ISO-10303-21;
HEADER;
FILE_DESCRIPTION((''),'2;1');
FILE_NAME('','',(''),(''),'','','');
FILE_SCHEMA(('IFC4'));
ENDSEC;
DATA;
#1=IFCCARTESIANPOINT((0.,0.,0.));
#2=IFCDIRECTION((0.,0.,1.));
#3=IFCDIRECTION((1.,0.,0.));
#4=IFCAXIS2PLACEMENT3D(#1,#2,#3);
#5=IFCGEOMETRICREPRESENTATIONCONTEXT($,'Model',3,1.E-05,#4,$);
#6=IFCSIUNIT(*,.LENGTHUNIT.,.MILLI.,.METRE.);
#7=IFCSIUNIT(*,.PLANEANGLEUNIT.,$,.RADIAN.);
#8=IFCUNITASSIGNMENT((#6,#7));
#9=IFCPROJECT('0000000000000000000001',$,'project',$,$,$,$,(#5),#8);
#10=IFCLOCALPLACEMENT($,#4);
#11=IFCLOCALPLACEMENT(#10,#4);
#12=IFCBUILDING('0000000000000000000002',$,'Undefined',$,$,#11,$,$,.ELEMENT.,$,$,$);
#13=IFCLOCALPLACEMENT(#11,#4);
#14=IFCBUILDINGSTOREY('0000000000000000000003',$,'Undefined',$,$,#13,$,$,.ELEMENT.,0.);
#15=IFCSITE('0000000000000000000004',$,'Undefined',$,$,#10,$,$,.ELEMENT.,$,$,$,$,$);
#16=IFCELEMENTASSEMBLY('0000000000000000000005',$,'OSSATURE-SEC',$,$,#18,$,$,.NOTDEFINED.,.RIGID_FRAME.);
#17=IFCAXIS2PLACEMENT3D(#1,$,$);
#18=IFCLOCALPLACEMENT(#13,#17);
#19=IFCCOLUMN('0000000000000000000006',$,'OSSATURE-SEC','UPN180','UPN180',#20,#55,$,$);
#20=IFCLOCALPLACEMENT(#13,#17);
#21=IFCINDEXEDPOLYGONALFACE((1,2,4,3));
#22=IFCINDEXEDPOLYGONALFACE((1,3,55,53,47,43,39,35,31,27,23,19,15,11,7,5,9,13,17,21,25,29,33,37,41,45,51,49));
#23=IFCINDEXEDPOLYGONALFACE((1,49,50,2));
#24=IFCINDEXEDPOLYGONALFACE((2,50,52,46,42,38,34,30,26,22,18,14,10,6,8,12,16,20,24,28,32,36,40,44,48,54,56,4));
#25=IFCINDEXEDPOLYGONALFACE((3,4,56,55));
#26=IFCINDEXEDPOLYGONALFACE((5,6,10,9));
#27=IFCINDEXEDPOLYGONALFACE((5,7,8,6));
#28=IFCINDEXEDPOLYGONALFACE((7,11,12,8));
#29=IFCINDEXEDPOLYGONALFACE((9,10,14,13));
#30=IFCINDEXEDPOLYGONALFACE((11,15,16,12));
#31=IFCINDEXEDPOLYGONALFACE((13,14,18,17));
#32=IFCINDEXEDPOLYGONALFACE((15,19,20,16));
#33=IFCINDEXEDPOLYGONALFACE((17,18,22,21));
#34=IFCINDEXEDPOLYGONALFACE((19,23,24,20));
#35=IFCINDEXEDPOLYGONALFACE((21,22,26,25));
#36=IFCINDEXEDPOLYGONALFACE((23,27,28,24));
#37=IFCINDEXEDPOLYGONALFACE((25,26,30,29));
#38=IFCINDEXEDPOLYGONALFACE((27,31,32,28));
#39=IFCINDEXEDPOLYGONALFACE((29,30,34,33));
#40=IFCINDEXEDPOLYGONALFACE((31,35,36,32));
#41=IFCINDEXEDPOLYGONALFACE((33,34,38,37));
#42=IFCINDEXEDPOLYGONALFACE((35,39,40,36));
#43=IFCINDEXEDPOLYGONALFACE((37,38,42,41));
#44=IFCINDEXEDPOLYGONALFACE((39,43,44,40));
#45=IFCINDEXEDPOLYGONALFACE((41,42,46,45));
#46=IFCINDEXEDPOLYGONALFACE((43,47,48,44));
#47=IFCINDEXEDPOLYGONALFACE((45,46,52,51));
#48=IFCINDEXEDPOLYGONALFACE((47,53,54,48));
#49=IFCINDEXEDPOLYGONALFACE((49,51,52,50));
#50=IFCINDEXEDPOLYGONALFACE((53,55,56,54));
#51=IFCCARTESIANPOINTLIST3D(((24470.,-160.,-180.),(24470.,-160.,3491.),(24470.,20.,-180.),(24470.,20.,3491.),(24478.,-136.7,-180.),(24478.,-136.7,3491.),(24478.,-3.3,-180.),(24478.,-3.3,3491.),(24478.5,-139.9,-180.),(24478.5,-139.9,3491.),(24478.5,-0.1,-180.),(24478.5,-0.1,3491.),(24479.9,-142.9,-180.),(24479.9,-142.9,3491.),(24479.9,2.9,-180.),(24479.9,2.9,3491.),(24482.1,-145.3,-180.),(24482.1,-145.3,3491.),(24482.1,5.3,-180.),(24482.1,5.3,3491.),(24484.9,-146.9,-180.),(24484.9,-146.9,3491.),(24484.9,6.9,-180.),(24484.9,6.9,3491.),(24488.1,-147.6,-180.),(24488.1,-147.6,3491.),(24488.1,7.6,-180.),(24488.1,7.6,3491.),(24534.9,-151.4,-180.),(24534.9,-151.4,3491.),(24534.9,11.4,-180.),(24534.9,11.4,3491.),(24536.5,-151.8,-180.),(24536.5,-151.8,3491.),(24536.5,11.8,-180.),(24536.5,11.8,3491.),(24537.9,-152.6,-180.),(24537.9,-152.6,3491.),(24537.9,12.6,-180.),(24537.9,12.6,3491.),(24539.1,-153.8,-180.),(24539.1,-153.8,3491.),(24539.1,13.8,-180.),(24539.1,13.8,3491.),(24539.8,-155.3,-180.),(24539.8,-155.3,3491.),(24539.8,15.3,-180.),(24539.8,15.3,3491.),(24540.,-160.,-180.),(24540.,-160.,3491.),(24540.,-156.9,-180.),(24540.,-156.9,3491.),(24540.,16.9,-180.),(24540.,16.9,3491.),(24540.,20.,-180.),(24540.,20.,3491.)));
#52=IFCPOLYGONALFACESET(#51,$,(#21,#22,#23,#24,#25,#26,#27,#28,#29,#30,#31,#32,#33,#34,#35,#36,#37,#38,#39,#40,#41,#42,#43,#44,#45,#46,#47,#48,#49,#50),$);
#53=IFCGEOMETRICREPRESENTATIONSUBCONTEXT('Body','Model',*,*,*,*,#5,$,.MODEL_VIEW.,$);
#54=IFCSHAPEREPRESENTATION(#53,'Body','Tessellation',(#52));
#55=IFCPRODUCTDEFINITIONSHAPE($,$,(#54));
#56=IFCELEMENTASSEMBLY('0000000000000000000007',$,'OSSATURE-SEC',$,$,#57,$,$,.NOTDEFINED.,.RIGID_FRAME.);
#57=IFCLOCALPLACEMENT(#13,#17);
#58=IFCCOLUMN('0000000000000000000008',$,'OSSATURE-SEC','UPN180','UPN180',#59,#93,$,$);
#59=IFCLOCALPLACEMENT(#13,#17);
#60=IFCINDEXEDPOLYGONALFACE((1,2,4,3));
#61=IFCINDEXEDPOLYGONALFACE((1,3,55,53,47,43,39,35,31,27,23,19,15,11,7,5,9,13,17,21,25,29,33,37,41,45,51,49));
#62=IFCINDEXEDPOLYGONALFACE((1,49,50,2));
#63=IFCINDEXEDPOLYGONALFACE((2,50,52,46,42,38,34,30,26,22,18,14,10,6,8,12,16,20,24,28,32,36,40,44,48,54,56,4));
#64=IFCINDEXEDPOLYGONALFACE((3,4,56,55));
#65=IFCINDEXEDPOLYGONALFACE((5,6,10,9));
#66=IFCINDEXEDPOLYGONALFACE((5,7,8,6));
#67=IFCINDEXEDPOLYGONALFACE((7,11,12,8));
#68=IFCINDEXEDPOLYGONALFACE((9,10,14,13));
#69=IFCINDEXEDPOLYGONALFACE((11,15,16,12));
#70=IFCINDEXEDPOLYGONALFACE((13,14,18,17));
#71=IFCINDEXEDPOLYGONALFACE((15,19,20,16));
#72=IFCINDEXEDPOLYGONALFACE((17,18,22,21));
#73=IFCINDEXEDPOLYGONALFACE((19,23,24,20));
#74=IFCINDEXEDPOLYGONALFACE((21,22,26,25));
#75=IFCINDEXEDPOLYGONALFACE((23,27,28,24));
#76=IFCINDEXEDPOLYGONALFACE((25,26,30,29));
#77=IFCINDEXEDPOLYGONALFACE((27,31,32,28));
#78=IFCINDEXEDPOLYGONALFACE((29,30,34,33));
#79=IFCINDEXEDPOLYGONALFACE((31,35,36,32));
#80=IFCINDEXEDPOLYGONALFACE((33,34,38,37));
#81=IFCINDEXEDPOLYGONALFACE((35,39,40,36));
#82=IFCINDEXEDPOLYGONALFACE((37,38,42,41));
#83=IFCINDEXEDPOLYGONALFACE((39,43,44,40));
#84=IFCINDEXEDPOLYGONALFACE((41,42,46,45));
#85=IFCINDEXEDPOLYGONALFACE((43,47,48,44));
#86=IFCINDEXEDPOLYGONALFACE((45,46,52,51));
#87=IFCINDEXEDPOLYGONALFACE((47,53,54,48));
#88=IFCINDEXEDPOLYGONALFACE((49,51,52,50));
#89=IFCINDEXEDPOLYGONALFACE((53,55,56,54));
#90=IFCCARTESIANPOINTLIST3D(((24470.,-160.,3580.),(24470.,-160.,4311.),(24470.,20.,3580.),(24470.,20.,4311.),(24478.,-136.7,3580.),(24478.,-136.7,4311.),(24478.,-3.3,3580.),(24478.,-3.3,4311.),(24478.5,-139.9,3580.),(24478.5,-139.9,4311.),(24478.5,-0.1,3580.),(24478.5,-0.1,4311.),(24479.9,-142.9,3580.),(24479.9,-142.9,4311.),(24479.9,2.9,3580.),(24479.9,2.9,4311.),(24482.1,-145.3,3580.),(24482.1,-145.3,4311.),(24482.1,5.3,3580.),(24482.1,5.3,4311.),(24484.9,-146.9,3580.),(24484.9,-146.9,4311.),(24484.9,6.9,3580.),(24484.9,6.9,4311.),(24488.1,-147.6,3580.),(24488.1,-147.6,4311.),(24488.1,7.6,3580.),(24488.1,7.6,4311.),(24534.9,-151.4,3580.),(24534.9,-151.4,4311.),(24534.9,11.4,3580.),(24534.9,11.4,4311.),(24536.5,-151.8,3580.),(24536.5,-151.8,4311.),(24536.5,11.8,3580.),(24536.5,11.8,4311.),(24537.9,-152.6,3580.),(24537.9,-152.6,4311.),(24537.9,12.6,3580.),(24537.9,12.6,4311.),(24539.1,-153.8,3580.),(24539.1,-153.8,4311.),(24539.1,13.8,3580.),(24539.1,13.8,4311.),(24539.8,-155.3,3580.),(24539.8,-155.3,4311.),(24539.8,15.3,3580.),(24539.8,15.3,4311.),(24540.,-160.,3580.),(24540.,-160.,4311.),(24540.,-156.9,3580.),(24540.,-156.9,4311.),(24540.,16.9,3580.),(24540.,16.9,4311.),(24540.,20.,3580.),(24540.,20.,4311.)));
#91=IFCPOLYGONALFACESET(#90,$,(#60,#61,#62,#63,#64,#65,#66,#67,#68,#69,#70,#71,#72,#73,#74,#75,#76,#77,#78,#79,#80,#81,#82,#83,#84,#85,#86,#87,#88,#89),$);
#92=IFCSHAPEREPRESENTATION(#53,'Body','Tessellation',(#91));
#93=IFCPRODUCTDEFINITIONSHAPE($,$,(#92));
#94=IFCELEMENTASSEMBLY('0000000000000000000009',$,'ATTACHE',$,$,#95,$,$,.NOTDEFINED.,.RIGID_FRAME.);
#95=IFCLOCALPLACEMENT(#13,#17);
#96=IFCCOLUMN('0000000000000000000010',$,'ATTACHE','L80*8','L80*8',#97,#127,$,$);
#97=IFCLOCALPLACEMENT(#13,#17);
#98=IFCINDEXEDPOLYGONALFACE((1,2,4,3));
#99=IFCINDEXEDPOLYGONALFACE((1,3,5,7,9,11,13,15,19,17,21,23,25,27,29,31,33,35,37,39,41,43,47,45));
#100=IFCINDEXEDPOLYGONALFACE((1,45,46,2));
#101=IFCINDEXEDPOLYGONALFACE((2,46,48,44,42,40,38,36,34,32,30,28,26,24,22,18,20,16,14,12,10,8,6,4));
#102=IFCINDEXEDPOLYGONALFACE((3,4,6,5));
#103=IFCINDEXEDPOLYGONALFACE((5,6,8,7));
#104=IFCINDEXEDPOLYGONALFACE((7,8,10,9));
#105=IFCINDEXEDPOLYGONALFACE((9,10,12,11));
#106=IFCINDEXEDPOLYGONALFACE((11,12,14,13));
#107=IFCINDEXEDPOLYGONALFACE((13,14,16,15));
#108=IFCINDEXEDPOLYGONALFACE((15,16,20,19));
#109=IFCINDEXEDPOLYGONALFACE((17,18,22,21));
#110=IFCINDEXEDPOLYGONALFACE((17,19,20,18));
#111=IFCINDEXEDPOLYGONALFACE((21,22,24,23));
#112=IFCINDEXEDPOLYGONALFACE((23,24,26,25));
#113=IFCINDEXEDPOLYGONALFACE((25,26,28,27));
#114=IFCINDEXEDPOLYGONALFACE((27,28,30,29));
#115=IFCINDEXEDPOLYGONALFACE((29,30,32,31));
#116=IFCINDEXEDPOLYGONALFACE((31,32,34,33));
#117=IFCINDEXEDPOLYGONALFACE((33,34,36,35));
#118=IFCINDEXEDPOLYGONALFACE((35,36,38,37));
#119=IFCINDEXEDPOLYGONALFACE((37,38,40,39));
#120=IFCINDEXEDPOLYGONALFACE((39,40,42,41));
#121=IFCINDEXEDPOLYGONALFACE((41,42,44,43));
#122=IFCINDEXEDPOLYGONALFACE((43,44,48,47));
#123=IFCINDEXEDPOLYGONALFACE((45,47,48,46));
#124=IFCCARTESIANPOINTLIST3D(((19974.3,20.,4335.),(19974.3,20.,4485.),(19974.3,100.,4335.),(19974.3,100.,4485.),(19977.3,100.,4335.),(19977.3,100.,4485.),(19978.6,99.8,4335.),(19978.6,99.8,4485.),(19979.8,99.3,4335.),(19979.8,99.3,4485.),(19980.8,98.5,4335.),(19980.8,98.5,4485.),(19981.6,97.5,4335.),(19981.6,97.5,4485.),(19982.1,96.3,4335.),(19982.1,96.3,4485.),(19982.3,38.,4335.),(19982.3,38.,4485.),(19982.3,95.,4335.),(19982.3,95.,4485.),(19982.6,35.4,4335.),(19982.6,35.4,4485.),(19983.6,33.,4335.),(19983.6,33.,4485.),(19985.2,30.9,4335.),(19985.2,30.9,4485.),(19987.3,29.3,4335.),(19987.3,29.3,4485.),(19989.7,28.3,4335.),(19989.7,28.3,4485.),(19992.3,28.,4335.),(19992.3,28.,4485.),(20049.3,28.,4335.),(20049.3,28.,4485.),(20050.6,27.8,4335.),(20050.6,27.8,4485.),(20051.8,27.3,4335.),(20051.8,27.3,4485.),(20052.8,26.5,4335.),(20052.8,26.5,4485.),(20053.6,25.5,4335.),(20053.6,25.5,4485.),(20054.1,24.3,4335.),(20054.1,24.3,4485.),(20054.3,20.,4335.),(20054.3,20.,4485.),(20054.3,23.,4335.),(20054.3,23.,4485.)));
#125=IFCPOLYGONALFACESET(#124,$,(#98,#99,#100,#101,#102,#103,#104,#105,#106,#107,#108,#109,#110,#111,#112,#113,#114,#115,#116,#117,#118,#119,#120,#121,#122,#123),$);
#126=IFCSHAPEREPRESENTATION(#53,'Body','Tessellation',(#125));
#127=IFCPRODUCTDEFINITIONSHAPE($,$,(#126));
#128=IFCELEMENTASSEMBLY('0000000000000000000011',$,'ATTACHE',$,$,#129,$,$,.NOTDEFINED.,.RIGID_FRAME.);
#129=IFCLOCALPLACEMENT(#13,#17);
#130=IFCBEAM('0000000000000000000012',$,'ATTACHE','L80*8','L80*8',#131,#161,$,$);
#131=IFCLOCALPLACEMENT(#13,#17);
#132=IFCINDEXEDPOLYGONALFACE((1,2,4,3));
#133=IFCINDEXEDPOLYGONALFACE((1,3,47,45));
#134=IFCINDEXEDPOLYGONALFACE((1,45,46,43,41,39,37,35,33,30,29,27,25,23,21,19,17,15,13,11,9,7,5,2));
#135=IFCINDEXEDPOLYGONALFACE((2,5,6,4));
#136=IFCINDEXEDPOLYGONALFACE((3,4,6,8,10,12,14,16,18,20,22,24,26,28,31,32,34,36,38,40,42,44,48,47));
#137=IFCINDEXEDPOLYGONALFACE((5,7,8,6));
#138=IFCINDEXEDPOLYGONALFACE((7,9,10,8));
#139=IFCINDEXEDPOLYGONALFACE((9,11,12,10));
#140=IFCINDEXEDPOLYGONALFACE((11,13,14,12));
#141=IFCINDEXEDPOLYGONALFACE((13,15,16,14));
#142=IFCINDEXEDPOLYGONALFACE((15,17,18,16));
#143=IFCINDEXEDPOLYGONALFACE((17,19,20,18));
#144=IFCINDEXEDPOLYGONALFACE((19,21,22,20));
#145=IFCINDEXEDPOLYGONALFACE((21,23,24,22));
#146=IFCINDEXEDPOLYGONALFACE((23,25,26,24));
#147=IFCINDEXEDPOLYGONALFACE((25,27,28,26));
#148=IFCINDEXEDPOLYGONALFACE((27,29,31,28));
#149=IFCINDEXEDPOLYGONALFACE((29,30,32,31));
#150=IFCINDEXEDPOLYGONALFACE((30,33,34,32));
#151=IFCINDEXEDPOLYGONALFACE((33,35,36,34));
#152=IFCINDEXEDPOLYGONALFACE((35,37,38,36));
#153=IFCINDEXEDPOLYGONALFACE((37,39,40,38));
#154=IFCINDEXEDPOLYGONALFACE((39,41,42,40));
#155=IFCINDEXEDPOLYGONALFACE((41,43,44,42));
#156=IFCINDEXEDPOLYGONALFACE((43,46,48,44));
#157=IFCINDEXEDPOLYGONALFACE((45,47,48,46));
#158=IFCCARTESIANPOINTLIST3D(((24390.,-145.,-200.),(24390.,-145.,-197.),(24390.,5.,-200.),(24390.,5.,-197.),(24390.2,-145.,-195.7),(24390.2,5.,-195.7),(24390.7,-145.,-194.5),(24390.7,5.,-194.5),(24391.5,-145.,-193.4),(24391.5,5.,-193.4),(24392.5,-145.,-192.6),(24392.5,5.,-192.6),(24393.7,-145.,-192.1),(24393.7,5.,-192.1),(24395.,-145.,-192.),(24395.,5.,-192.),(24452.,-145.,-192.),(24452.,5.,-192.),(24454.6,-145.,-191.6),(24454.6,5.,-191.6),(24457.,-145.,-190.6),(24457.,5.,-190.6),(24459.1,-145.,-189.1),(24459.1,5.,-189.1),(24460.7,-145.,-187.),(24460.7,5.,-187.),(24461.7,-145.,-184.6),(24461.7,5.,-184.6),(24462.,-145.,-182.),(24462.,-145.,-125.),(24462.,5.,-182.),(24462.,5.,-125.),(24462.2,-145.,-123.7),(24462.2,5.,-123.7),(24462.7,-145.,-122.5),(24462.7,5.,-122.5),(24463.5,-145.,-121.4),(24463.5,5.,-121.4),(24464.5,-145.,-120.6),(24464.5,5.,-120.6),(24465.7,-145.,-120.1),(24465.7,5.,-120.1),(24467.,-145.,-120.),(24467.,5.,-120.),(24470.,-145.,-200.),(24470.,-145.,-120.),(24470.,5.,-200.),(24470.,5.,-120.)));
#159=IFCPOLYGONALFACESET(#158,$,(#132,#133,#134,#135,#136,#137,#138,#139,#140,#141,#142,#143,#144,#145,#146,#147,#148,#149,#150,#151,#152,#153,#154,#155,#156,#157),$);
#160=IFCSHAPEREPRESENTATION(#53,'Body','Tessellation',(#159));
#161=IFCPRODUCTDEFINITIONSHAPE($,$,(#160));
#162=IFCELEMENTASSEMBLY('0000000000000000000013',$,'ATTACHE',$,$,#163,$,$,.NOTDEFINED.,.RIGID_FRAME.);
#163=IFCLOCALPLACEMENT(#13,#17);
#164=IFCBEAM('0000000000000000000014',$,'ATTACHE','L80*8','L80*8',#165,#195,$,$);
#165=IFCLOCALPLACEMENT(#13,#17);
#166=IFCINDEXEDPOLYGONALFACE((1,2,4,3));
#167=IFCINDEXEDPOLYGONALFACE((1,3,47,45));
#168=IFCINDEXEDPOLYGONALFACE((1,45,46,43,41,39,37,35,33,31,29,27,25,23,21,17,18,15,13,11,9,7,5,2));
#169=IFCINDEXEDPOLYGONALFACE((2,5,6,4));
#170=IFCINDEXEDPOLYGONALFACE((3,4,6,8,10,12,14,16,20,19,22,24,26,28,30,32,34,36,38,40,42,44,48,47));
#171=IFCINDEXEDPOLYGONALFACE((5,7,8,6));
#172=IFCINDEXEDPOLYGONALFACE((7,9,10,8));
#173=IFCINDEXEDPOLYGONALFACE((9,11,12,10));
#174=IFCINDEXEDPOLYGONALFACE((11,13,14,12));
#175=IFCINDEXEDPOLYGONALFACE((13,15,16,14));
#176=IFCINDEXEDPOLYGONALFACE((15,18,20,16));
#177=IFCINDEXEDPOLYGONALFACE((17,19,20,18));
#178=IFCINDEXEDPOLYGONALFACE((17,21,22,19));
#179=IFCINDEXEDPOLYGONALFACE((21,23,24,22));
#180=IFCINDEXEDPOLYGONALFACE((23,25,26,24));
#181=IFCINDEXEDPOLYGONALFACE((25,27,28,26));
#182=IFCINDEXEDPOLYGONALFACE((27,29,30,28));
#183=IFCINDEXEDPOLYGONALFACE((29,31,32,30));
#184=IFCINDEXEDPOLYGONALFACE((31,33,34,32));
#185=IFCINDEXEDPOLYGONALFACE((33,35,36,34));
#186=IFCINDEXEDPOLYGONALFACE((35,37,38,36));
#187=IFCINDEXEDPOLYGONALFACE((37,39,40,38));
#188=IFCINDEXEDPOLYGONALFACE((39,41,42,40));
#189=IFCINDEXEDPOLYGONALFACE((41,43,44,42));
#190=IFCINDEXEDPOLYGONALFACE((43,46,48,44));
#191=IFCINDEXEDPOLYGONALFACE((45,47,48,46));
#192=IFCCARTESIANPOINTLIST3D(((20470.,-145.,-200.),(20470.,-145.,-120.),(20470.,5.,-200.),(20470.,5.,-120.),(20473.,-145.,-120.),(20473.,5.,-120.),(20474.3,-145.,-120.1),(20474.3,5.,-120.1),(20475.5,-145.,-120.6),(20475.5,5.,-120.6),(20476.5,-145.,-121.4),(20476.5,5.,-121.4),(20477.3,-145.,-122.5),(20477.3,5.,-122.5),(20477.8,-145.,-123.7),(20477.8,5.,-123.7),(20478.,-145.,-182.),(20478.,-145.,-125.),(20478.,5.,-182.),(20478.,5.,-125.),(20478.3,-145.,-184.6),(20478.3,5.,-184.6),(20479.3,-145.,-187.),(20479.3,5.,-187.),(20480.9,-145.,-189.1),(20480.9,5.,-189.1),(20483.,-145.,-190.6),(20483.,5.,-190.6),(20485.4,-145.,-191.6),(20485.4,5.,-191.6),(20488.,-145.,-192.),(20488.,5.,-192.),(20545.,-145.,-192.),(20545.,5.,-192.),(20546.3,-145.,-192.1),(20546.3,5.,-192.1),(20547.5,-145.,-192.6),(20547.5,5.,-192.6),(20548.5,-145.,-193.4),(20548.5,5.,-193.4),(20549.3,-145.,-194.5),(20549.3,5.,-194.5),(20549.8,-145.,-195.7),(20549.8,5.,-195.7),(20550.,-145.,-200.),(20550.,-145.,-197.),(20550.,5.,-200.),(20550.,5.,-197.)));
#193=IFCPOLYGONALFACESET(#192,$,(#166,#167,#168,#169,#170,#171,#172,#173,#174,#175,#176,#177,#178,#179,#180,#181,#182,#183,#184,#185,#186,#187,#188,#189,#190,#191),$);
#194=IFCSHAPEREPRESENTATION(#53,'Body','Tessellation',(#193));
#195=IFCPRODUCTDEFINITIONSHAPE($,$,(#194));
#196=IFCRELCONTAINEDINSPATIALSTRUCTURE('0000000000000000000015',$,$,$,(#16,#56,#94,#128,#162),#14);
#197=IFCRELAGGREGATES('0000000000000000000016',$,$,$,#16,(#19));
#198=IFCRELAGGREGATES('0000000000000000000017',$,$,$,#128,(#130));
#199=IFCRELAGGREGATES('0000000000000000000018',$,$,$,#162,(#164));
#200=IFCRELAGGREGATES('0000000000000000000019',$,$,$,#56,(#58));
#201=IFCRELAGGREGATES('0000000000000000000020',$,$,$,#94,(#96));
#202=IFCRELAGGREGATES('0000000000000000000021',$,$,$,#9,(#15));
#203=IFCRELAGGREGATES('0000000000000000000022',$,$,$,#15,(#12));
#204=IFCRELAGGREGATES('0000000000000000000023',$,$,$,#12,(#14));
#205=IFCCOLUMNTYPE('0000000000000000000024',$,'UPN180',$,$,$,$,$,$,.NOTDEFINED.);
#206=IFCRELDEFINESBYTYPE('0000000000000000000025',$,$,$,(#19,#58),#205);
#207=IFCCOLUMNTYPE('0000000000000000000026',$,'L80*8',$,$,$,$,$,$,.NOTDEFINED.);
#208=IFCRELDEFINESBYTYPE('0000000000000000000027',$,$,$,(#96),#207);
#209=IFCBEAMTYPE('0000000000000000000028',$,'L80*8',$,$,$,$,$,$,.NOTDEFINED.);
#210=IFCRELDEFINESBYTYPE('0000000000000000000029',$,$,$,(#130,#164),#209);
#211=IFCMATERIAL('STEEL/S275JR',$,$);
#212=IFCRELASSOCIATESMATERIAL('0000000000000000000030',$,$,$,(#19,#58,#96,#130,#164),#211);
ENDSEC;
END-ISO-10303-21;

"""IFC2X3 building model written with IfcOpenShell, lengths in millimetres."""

from ifc_helpers import new_model, si_unit, frame, origin_with_axes, origin_2d_with_axis, place, context, subcontext, project, spatial, l_section, u_section, extrude, clip, halfspace, material, type_object, element, aggregate, save


model = new_model("IFC2X3")

# Units and contexts
model_context = context("Model", 3, precision=1e-05, world=origin_with_axes())
body_context = subcontext(model_context, "Body", "Model", "MODEL_VIEW")
ifc_project = project(units=[si_unit("LENGTHUNIT", "METRE", prefix="MILLI"), si_unit("PLANEANGLEUNIT", "RADIAN")], contexts=[model_context])

# Site, building, storey
site_placement = place(None, origin_with_axes())
site = spatial("IfcSite", under=ifc_project, at=site_placement, Name="Undefined", CompositionType="ELEMENT")
building_placement = place(site_placement, origin_with_axes())
building = spatial("IfcBuilding", under=site, at=building_placement, Name="Undefined", CompositionType="ELEMENT")
storey_placement = place(building_placement, origin_with_axes())
storey = spatial("IfcBuildingStorey", under=building, at=storey_placement, Name="Undefined", CompositionType="ELEMENT", Elevation=0.0)

# Element assemblies, columns
assembly_1_placement = place(storey_placement, origin_with_axes())
assembly_1 = element("IfcElementAssembly", 1, at=assembly_1_placement, inside=storey, Name="OSSATURE-SEC", AssemblyPlace="NOTDEFINED", PredefinedType="RIGID_FRAME")
ifc_material_1 = material(Name="STEEL/S275JR")
column_type_1 = type_object("IfcColumnType", Name="UPN180", PredefinedType="NOTDEFINED")
column_1_placement = place(assembly_1_placement, frame((24505.0, -70.0, -200.0), z_axis=(0.0, 0.0, 1.0), x_axis=(0.0, -1.0, 0.0)))
column_1 = element("IfcColumn", 2, at=column_1_placement, type_object=column_type_1, material=ifc_material_1, Name="OSSATURE-SEC", Description="UPN180", ObjectType="UPN180", context=body_context, shape_type="Clipping", body=[
    clip(clip(extrude(u_section(Depth=180.0, FlangeWidth=70.0, WebThickness=8.0, FlangeThickness=11.0, FilletRadius=11.0, EdgeRadius=5.5, FlangeSlope=0.07983, at=origin_2d_with_axis()), frame((0.0, 0.0, 3691.0), z_axis=(0.0, 0.0, -1.0), x_axis=(0.0, 1.0, 0.0)), (0.0, 0.0, 1.0), 3671.0), halfspace(frame((-90.0, 0.0, 3691.0), z_axis=(0.0, 0.0, -1.0), x_axis=(1.0, 0.0, 0.0)), True)), halfspace(frame((90.0, -22.5, 20.0), z_axis=(0.0, 0.0, -1.0), x_axis=(1.0, 0.0, 0.0)), False)),
])
assembly_2_placement = place(storey_placement, origin_with_axes())
assembly_2 = element("IfcElementAssembly", 3, at=assembly_2_placement, inside=storey, Name="OSSATURE-SEC", AssemblyPlace="NOTDEFINED", PredefinedType="RIGID_FRAME")
column_2_placement = place(assembly_2_placement, frame((24505.0, -70.0, 3500.0), z_axis=(0.0, 0.0, 1.0), x_axis=(0.0, -1.0, 0.0)))
column_2 = element("IfcColumn", 4, at=column_2_placement, type_object=column_type_1, material=ifc_material_1, Name="OSSATURE-SEC", Description="UPN180", ObjectType="UPN180", context=body_context, shape_type="Clipping", body=[
    clip(clip(extrude(u_section(Depth=180.0, FlangeWidth=70.0, WebThickness=8.0, FlangeThickness=11.0, FilletRadius=11.0, EdgeRadius=5.5, FlangeSlope=0.07983, at=origin_2d_with_axis()), frame((0.0, 0.0, 811.0), z_axis=(0.0, 0.0, -1.0), x_axis=(0.0, 1.0, 0.0)), (0.0, 0.0, 1.0), 731.0), halfspace(frame((90.0, -25.1, 811.0), z_axis=(0.0, 0.0, 1.0), x_axis=(0.0, 1.0, 0.0)), False)), halfspace(frame((190.0, 0.0, 80.0), z_axis=(0.0, 0.0, -1.0), x_axis=(0.0, 1.0, 0.0)), False)),
])
assembly_3_placement = place(storey_placement, origin_with_axes())
assembly_3 = element("IfcElementAssembly", 5, at=assembly_3_placement, inside=storey, Name="ATTACHE", AssemblyPlace="NOTDEFINED", PredefinedType="RIGID_FRAME")
column_type_2 = type_object("IfcColumnType", Name="L80*8", PredefinedType="NOTDEFINED")
column_3_placement = place(assembly_3_placement, frame((20014.3, 60.0, 4335.0), z_axis=(0.0, 0.0, 1.0), x_axis=(1.0, 0.000104, 0.0)))
column_3 = element("IfcColumn", 6, at=column_3_placement, type_object=column_type_2, material=ifc_material_1, Name="ATTACHE", Description="L80*8", ObjectType="L80*8", context=body_context, shape_type="SweptSolid", body=[
    extrude(l_section(Depth=80.0, Width=80.0, Thickness=8.0, FilletRadius=10.0, EdgeRadius=5.0, at=origin_2d_with_axis()), frame((0.0, 0.0, 150.0), z_axis=(0.0, 0.0, -1.0), x_axis=(0.0, 1.0, 0.0)), (0.0, 0.0, 1.0), 150.0),
])

# Element assemblies, beams
assembly_4_placement = place(storey_placement, origin_with_axes())
assembly_4 = element("IfcElementAssembly", 7, at=assembly_4_placement, inside=storey, Name="ATTACHE", AssemblyPlace="NOTDEFINED", PredefinedType="RIGID_FRAME")
beam_type_1 = type_object("IfcBeamType", Name="L80*8", PredefinedType="NOTDEFINED")
beam_1_placement = place(assembly_4_placement, frame((24430.0, 5.0, -160.0), z_axis=(0.0, 0.0, 1.0), x_axis=(0.0, -1.0, 0.0)))
beam_1 = element("IfcBeam", 8, at=beam_1_placement, type_object=beam_type_1, material=ifc_material_1, Name="ATTACHE", Description="L80*8", ObjectType="L80*8", context=body_context, shape_type="SweptSolid", body=[
    extrude(l_section(Depth=80.0, Width=80.0, Thickness=8.0, FilletRadius=10.0, EdgeRadius=5.0, at=origin_2d_with_axis()), frame((150.0, 0.0, 0.0), z_axis=(-1.0, 0.0, 0.0), x_axis=(0.0, -1.0, 0.0)), (0.0, 0.0, 1.0), 150.0),
])
assembly_5_placement = place(storey_placement, origin_with_axes())
assembly_5 = element("IfcElementAssembly", 9, at=assembly_5_placement, inside=storey, Name="ATTACHE", AssemblyPlace="NOTDEFINED", PredefinedType="RIGID_FRAME")
beam_2_placement = place(assembly_5_placement, frame((20510.0, -145.0, -160.0), z_axis=(0.0, 0.0, 1.0), x_axis=(0.0, 1.0, 0.0)))
beam_2 = element("IfcBeam", 10, at=beam_2_placement, type_object=beam_type_1, material=ifc_material_1, Name="ATTACHE", Description="L80*8", ObjectType="L80*8", context=body_context, shape_type="SweptSolid", body=[
    extrude(l_section(Depth=80.0, Width=80.0, Thickness=8.0, FilletRadius=10.0, EdgeRadius=5.0, at=origin_2d_with_axis()), frame((150.0, 0.0, 0.0), z_axis=(-1.0, 0.0, 0.0), x_axis=(0.0, -1.0, 0.0)), (0.0, 0.0, 1.0), 150.0),
])

aggregate(assembly_1, [column_1])

aggregate(assembly_4, [beam_1])
aggregate(assembly_5, [beam_2])
aggregate(assembly_2, [column_2])

aggregate(assembly_3, [column_3])

save(model, "model.ifc")
